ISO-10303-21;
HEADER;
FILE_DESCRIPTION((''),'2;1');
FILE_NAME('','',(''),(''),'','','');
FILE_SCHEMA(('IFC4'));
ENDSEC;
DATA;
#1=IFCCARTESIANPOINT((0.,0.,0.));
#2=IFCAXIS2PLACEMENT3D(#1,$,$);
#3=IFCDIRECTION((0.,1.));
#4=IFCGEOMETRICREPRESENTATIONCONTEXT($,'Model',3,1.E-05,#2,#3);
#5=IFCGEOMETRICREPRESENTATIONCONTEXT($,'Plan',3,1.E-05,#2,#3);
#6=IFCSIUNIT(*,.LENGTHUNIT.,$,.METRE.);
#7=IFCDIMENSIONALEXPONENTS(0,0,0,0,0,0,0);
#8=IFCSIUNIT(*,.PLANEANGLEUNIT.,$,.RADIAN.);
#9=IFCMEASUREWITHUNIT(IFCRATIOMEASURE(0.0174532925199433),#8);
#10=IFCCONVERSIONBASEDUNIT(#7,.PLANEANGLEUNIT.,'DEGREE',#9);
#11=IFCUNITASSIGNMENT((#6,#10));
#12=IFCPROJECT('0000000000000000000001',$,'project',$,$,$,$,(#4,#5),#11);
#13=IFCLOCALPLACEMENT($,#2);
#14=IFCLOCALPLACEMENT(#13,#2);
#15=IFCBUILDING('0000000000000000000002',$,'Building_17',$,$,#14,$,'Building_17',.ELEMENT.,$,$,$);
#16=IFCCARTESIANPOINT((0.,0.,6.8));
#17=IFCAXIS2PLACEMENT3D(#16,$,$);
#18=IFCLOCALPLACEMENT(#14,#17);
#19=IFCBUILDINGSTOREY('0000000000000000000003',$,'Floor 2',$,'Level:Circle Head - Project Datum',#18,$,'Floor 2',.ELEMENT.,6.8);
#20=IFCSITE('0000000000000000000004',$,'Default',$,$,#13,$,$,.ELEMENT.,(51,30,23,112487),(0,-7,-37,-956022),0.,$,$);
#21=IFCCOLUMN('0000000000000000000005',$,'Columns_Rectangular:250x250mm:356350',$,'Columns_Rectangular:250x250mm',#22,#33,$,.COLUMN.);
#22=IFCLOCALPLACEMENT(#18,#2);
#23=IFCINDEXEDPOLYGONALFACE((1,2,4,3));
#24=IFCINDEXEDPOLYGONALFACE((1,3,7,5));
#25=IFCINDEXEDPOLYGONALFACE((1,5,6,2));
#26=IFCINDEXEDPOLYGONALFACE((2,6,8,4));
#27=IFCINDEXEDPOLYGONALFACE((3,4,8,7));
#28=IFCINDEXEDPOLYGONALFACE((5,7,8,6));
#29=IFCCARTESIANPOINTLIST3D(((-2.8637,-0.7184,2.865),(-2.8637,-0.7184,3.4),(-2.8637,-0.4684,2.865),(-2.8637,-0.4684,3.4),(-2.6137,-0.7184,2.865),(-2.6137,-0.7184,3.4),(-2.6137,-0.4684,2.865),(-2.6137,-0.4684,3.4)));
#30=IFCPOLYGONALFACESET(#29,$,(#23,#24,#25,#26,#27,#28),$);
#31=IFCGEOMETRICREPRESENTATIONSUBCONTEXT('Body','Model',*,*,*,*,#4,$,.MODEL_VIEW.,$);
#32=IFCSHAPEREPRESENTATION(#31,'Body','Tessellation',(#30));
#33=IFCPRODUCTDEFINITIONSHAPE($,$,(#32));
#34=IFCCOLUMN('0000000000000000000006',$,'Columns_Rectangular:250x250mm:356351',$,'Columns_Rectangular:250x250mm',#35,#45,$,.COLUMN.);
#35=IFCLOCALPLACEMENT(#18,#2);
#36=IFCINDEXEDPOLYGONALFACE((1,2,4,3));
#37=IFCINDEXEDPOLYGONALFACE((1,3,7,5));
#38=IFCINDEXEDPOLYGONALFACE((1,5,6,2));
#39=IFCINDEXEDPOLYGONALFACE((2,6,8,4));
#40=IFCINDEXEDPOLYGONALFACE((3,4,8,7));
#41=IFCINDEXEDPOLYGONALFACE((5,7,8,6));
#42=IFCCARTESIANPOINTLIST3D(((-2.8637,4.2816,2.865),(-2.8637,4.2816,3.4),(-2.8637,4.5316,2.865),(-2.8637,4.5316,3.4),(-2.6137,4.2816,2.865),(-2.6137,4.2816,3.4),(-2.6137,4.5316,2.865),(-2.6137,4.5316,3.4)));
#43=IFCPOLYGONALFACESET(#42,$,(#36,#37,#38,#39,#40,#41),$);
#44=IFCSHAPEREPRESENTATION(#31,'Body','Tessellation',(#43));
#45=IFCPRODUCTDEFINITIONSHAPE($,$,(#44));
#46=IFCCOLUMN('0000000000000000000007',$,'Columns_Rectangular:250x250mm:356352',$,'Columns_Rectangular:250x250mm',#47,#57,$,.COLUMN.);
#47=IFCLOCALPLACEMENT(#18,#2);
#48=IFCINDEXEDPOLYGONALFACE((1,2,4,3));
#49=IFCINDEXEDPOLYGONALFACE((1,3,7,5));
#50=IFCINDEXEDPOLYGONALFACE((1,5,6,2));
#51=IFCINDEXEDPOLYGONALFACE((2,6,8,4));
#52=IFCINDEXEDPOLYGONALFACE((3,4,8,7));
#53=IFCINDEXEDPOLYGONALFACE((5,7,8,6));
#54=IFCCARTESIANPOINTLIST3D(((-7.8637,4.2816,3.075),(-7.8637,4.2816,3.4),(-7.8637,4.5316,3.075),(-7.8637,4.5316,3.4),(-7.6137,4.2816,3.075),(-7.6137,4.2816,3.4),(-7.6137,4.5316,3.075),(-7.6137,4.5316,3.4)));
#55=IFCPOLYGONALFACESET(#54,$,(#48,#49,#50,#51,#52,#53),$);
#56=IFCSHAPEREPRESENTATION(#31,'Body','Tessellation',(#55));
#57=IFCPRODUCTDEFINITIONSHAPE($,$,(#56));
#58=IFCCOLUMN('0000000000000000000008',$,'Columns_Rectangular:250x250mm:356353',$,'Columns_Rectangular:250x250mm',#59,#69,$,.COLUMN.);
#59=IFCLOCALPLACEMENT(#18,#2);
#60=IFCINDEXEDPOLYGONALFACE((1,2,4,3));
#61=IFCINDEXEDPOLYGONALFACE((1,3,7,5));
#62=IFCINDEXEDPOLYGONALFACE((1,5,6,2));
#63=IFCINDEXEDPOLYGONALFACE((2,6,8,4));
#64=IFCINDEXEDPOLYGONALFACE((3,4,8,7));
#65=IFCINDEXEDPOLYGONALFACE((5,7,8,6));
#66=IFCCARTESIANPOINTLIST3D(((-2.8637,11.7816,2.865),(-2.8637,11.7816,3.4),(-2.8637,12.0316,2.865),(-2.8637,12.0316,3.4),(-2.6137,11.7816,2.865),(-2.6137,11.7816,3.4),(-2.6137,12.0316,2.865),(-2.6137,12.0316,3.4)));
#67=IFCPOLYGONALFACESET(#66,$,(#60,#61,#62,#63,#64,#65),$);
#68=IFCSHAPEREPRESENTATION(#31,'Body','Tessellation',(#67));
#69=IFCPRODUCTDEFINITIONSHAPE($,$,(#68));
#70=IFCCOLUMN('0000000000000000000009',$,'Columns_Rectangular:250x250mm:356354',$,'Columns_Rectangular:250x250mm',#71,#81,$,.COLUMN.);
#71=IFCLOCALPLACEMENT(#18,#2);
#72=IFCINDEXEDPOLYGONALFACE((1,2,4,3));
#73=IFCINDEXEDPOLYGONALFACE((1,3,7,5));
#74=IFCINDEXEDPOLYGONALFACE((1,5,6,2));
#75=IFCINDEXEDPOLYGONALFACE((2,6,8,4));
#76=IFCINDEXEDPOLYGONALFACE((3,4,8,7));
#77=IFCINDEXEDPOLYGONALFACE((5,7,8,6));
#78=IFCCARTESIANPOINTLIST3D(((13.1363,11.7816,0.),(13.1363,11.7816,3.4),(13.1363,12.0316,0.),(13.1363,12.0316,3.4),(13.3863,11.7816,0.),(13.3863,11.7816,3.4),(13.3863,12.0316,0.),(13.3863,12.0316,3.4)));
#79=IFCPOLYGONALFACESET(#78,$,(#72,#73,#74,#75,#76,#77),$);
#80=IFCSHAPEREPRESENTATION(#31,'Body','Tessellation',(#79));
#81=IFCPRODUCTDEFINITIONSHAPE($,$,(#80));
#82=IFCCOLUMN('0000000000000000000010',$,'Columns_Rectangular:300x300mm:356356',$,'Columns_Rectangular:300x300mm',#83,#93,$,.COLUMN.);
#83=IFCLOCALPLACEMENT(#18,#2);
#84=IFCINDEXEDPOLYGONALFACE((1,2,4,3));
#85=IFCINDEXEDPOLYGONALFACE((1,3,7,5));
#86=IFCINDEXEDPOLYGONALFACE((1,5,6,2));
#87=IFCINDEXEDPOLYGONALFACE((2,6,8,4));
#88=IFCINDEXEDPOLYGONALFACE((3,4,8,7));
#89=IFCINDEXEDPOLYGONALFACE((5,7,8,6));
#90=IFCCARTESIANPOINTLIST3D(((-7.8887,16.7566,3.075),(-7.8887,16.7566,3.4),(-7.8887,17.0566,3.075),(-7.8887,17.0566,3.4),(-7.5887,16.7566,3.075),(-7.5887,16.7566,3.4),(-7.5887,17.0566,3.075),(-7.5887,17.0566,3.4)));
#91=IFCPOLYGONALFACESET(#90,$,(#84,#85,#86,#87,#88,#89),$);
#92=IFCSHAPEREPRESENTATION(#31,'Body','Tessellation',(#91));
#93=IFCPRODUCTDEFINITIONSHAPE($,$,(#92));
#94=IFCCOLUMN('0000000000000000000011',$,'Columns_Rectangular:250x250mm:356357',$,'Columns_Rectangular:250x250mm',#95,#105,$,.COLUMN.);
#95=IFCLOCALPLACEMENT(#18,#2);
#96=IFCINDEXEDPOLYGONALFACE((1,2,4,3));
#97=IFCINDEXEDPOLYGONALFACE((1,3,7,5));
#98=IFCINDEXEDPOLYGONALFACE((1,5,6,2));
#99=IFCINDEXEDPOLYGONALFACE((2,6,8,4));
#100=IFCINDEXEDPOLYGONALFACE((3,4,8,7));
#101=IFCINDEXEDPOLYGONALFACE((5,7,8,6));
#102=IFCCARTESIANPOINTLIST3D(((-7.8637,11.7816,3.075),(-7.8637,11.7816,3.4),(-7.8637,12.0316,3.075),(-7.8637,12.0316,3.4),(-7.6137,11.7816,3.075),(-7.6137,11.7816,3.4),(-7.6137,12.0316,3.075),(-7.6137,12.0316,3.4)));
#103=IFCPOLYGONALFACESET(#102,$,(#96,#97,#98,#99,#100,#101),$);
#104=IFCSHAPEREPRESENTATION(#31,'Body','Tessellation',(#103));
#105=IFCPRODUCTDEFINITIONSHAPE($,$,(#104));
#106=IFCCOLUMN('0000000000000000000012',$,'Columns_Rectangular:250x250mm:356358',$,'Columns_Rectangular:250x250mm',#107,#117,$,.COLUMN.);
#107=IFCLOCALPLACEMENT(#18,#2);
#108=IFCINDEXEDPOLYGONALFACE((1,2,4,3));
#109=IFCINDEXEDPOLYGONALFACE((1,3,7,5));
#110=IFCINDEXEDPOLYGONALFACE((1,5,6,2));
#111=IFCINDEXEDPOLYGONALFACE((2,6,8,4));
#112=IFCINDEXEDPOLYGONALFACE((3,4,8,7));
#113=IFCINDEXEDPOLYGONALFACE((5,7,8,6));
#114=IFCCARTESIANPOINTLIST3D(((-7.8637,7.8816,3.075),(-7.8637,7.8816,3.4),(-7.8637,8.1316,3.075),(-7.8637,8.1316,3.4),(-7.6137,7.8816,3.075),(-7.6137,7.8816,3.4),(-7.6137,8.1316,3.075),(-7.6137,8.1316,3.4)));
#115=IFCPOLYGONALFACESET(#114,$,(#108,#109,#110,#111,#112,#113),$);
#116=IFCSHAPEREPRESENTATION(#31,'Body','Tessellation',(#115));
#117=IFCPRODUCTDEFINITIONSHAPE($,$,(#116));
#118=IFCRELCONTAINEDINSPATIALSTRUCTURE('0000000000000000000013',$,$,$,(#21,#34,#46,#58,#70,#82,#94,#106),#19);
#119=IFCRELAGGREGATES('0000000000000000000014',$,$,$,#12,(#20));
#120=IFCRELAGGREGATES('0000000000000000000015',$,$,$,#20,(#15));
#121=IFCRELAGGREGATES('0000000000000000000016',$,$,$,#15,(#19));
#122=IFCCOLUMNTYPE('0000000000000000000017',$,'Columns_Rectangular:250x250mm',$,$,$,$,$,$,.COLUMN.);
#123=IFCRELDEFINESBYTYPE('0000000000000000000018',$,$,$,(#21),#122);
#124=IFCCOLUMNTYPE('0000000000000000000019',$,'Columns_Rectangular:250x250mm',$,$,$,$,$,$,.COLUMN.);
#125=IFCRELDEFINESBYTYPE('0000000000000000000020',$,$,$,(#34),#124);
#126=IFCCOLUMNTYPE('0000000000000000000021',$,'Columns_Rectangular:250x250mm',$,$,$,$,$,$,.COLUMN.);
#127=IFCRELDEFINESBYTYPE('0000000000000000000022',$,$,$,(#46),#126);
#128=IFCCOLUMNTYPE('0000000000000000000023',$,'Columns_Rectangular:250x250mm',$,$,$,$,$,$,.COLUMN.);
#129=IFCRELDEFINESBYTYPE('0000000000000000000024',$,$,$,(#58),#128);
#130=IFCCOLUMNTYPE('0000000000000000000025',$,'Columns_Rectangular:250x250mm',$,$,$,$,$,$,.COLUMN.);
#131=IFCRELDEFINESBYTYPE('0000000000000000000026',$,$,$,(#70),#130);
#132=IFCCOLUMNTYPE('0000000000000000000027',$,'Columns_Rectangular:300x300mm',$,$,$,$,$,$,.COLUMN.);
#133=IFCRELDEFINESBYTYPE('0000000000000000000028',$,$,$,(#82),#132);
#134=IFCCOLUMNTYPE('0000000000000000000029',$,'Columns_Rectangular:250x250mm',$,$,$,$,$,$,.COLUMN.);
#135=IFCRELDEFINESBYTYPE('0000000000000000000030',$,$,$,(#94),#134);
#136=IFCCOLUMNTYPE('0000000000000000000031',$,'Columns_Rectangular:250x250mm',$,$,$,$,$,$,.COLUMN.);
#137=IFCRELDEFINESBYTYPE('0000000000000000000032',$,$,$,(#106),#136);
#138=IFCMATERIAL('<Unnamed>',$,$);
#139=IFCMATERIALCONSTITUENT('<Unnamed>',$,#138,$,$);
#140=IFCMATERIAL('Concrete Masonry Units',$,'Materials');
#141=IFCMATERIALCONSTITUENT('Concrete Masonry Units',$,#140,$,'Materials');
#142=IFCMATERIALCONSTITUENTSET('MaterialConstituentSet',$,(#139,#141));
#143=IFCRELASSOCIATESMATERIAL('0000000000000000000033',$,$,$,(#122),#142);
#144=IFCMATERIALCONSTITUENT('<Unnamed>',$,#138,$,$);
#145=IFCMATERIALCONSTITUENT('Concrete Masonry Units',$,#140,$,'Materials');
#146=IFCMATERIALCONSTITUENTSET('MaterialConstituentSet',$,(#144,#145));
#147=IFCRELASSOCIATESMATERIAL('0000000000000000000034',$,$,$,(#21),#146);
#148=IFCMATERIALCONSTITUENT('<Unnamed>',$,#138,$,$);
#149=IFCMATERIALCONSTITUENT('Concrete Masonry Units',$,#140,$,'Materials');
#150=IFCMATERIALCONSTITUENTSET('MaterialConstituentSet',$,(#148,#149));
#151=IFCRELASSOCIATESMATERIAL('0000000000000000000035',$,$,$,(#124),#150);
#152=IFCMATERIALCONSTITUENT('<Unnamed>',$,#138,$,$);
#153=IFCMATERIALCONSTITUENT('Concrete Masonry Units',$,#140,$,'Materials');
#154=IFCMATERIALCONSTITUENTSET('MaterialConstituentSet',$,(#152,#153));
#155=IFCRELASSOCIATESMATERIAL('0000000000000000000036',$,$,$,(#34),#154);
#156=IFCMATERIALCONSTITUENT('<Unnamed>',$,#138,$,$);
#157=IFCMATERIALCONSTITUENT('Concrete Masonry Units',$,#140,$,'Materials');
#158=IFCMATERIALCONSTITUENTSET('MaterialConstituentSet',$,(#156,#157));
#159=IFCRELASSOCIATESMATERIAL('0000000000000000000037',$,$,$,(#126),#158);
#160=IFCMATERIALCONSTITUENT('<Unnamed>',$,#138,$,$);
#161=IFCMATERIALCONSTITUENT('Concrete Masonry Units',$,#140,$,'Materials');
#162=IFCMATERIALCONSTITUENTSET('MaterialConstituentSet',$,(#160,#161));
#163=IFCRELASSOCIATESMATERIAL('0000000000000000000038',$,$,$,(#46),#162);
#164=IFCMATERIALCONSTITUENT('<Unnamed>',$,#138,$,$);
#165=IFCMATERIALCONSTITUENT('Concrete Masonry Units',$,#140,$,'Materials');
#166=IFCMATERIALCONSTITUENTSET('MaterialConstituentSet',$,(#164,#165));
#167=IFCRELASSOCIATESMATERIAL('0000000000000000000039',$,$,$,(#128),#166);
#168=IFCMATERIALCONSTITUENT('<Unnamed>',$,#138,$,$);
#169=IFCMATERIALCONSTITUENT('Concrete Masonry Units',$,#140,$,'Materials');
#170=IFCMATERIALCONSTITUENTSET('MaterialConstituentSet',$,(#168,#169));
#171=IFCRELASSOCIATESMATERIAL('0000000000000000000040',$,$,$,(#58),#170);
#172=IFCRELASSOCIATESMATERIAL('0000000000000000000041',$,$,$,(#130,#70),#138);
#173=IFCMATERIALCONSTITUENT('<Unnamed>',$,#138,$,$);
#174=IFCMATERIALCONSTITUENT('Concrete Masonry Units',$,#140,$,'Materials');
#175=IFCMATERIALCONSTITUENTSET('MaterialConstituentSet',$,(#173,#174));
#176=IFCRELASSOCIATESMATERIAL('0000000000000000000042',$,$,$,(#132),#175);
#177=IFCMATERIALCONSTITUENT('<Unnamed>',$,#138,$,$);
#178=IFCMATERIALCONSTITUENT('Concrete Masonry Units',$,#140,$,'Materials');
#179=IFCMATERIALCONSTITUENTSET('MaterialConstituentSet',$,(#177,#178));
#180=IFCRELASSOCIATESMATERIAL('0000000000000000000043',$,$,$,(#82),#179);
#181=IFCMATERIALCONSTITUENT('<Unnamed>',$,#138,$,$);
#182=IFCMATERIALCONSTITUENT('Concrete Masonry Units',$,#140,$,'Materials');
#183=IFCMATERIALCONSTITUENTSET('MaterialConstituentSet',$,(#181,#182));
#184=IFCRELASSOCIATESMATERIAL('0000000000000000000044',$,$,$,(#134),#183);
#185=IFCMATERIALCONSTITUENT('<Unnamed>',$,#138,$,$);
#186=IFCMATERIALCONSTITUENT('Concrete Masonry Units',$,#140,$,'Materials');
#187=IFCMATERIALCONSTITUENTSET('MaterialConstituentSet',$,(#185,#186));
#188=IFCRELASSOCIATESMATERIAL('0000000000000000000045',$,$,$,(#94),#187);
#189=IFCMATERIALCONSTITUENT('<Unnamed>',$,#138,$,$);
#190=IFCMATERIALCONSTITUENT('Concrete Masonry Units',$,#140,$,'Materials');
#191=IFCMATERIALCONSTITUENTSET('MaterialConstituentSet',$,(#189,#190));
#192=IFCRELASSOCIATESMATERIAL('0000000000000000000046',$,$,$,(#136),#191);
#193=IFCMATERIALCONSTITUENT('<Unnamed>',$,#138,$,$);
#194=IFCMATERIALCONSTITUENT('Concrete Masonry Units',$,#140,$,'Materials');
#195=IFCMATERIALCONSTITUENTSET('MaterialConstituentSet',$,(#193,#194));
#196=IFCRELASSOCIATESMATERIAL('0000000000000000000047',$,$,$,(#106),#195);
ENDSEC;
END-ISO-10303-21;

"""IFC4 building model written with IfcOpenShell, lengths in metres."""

from ifc_helpers import new_model, entity, si_unit, converted_unit, direction, frame, origin, place, context, subcontext, project, spatial, indexed_curve, outline, extrude, source, transform, mapped, material, constituent, constituent_set, type_object, type_shapes, element, save


model = new_model("IFC4")

# Units and contexts
model_context = context("Model", 3, precision=1e-05, world=origin(), true_north=direction((0.0, 1.0)))
plan_context = context("Plan", 3, precision=1e-05, world=origin(), true_north=direction((0.0, 1.0)))
body_context = subcontext(model_context, "Body", "Model", "MODEL_VIEW")
ifc_project = project(units=[si_unit("LENGTHUNIT", "METRE"), converted_unit("PLANEANGLEUNIT", "DEGREE", entity("IfcRatioMeasure", 0.0174532925199433), si_unit("PLANEANGLEUNIT", "RADIAN"), dimensions=[0, 0, 0, 0, 0, 0, 0])], contexts=[model_context, plan_context])

# Site, building, storey
site_placement = place(None, origin())
site = spatial("IfcSite", under=ifc_project, at=site_placement, Name="Default", CompositionType="ELEMENT", RefLatitude=(51, 30, 23, 112487), RefLongitude=(0, -7, -37, -956022), RefElevation=0.0)
building_placement = place(site_placement, origin())
building = spatial("IfcBuilding", under=site, at=building_placement, Name="Building_17", LongName="Building_17", CompositionType="ELEMENT")
storey_placement = place(building_placement, frame((0.0, 0.0, 6.8)))
storey = spatial("IfcBuildingStorey", under=building, at=storey_placement, Name="Floor 2", ObjectType="Level:Circle Head - Project Datum", LongName="Floor 2", CompositionType="ELEMENT", Elevation=6.8)

# Columns
ifc_material_1 = material(Name="<Unnamed>")
ifc_constituent_1 = constituent(ifc_material_1, Name="<Unnamed>")
ifc_material_2 = material(Name="Concrete Masonry Units", Category="Materials")
ifc_constituent_2 = constituent(ifc_material_2, Name="Concrete Masonry Units", Category="Materials")
ifc_constituent_set_1 = constituent_set(constituents=[ifc_constituent_1, ifc_constituent_2], Name="MaterialConstituentSet")
ifc_constituent_3 = constituent(ifc_material_1, Name="<Unnamed>")
ifc_constituent_4 = constituent(ifc_material_2, Name="Concrete Masonry Units", Category="Materials")
ifc_constituent_set_2 = constituent_set(constituents=[ifc_constituent_3, ifc_constituent_4], Name="MaterialConstituentSet")
column_type_1 = type_object("IfcColumnType", Name="Columns_Rectangular:250x250mm", PredefinedType="COLUMN", material=ifc_constituent_set_2)
shared_shape_1 = source(origin(), body_context, "Body", "SweptSolid", [
    extrude(outline(indexed_curve([(-0.125, -0.125), (0.125, -0.125), (0.125, 0.125), (-0.125, 0.125), (-0.125, -0.125)], self_intersect=False)), frame((-2.7387, -0.5934, 9.665), z_axis=(0.0, 0.0, 1.0), x_axis=(0.0, -1.0, 0.0)), (0.0, 0.0, 1.0), 0.535),
])
type_shapes(column_type_1, [shared_shape_1])
column_1_placement = place(storey_placement, frame((0.0, 0.0, -6.8)))
element("IfcColumn", 1, at=column_1_placement, inside=storey, type_object=column_type_1, material=ifc_constituent_set_1, Name="Columns_Rectangular:250x250mm:356350", ObjectType="Columns_Rectangular:250x250mm", PredefinedType="COLUMN", context=body_context, shape_type="MappedRepresentation", body=[
    mapped(shared_shape_1, transform((0.0, 0.0, 0.0), scale=1.0)),
])
ifc_constituent_5 = constituent(ifc_material_1, Name="<Unnamed>")
ifc_constituent_6 = constituent(ifc_material_2, Name="Concrete Masonry Units", Category="Materials")
ifc_constituent_set_3 = constituent_set(constituents=[ifc_constituent_5, ifc_constituent_6], Name="MaterialConstituentSet")
ifc_constituent_7 = constituent(ifc_material_1, Name="<Unnamed>")
ifc_constituent_8 = constituent(ifc_material_2, Name="Concrete Masonry Units", Category="Materials")
ifc_constituent_set_4 = constituent_set(constituents=[ifc_constituent_7, ifc_constituent_8], Name="MaterialConstituentSet")
column_type_2 = type_object("IfcColumnType", Name="Columns_Rectangular:250x250mm", PredefinedType="COLUMN", material=ifc_constituent_set_4)
shared_shape_2 = source(origin(), body_context, "Body", "SweptSolid", [
    extrude(outline(indexed_curve([(-0.125, -0.125), (0.125, -0.125), (0.125, 0.125), (-0.125, 0.125), (-0.125, -0.125)], self_intersect=False)), frame((-2.7387, 4.4066, 9.665), z_axis=(0.0, 0.0, 1.0), x_axis=(0.0, -1.0, 0.0)), (0.0, 0.0, 1.0), 0.535),
])
type_shapes(column_type_2, [shared_shape_2])
column_2_placement = place(storey_placement, frame((0.0, 0.0, -6.8)))
element("IfcColumn", 2, at=column_2_placement, inside=storey, type_object=column_type_2, material=ifc_constituent_set_3, Name="Columns_Rectangular:250x250mm:356351", ObjectType="Columns_Rectangular:250x250mm", PredefinedType="COLUMN", context=body_context, shape_type="MappedRepresentation", body=[
    mapped(shared_shape_2, transform((0.0, 0.0, 0.0), scale=1.0)),
])
ifc_constituent_9 = constituent(ifc_material_1, Name="<Unnamed>")
ifc_constituent_10 = constituent(ifc_material_2, Name="Concrete Masonry Units", Category="Materials")
ifc_constituent_set_5 = constituent_set(constituents=[ifc_constituent_9, ifc_constituent_10], Name="MaterialConstituentSet")
ifc_constituent_11 = constituent(ifc_material_1, Name="<Unnamed>")
ifc_constituent_12 = constituent(ifc_material_2, Name="Concrete Masonry Units", Category="Materials")
ifc_constituent_set_6 = constituent_set(constituents=[ifc_constituent_11, ifc_constituent_12], Name="MaterialConstituentSet")
column_type_3 = type_object("IfcColumnType", Name="Columns_Rectangular:250x250mm", PredefinedType="COLUMN", material=ifc_constituent_set_6)
shared_shape_3 = source(origin(), body_context, "Body", "SweptSolid", [
    extrude(outline(indexed_curve([(-0.125, -0.125), (0.125, -0.125), (0.125, 0.125), (-0.125, 0.125), (-0.125, -0.125)], self_intersect=False)), frame((-7.7387, 4.4066, 9.875), z_axis=(0.0, 0.0, 1.0), x_axis=(0.0, -1.0, 0.0)), (0.0, 0.0, 1.0), 0.325),
])
type_shapes(column_type_3, [shared_shape_3])
column_3_placement = place(storey_placement, frame((0.0, 0.0, -6.8)))
element("IfcColumn", 3, at=column_3_placement, inside=storey, type_object=column_type_3, material=ifc_constituent_set_5, Name="Columns_Rectangular:250x250mm:356352", ObjectType="Columns_Rectangular:250x250mm", PredefinedType="COLUMN", context=body_context, shape_type="MappedRepresentation", body=[
    mapped(shared_shape_3, transform((0.0, 0.0, 0.0), scale=1.0)),
])
ifc_constituent_13 = constituent(ifc_material_1, Name="<Unnamed>")
ifc_constituent_14 = constituent(ifc_material_2, Name="Concrete Masonry Units", Category="Materials")
ifc_constituent_set_7 = constituent_set(constituents=[ifc_constituent_13, ifc_constituent_14], Name="MaterialConstituentSet")
ifc_constituent_15 = constituent(ifc_material_1, Name="<Unnamed>")
ifc_constituent_16 = constituent(ifc_material_2, Name="Concrete Masonry Units", Category="Materials")
ifc_constituent_set_8 = constituent_set(constituents=[ifc_constituent_15, ifc_constituent_16], Name="MaterialConstituentSet")
column_type_4 = type_object("IfcColumnType", Name="Columns_Rectangular:250x250mm", PredefinedType="COLUMN", material=ifc_constituent_set_8)
shared_shape_4 = source(origin(), body_context, "Body", "SweptSolid", [
    extrude(outline(indexed_curve([(-0.125, -0.125), (0.125, -0.125), (0.125, 0.125), (-0.125, 0.125), (-0.125, -0.125)], self_intersect=False)), frame((-2.7387, 11.9066, 9.665), z_axis=(0.0, 0.0, 1.0), x_axis=(0.0, -1.0, 0.0)), (0.0, 0.0, 1.0), 0.535),
])
type_shapes(column_type_4, [shared_shape_4])
column_4_placement = place(storey_placement, frame((0.0, 0.0, -6.8)))
element("IfcColumn", 4, at=column_4_placement, inside=storey, type_object=column_type_4, material=ifc_constituent_set_7, Name="Columns_Rectangular:250x250mm:356353", ObjectType="Columns_Rectangular:250x250mm", PredefinedType="COLUMN", context=body_context, shape_type="MappedRepresentation", body=[
    mapped(shared_shape_4, transform((0.0, 0.0, 0.0), scale=1.0)),
])
column_type_5 = type_object("IfcColumnType", Name="Columns_Rectangular:250x250mm", PredefinedType="COLUMN", material=ifc_material_1)
shared_shape_5 = source(origin(), body_context, "Body", "SweptSolid", [
    extrude(outline(indexed_curve([(-0.125, -0.125), (0.125, -0.125), (0.125, 0.125), (-0.125, 0.125), (-0.125, -0.125)], self_intersect=False)), frame((13.2613, 11.9066, 6.8), z_axis=(0.0, 0.0, 1.0), x_axis=(0.0, -1.0, 0.0)), (0.0, 0.0, 1.0), 3.4),
])
type_shapes(column_type_5, [shared_shape_5])
column_5_placement = place(storey_placement, frame((0.0, 0.0, -6.8)))
element("IfcColumn", 5, at=column_5_placement, inside=storey, type_object=column_type_5, material=ifc_material_1, Name="Columns_Rectangular:250x250mm:356354", ObjectType="Columns_Rectangular:250x250mm", PredefinedType="COLUMN", context=body_context, shape_type="MappedRepresentation", body=[
    mapped(shared_shape_5, transform((0.0, 0.0, 0.0), scale=1.0)),
])
ifc_constituent_17 = constituent(ifc_material_1, Name="<Unnamed>")
ifc_constituent_18 = constituent(ifc_material_2, Name="Concrete Masonry Units", Category="Materials")
ifc_constituent_set_9 = constituent_set(constituents=[ifc_constituent_17, ifc_constituent_18], Name="MaterialConstituentSet")
ifc_constituent_19 = constituent(ifc_material_1, Name="<Unnamed>")
ifc_constituent_20 = constituent(ifc_material_2, Name="Concrete Masonry Units", Category="Materials")
ifc_constituent_set_10 = constituent_set(constituents=[ifc_constituent_19, ifc_constituent_20], Name="MaterialConstituentSet")
column_type_6 = type_object("IfcColumnType", Name="Columns_Rectangular:300x300mm", PredefinedType="COLUMN", material=ifc_constituent_set_10)
shared_shape_6 = source(origin(), body_context, "Body", "SweptSolid", [
    extrude(outline(indexed_curve([(-0.15, -0.15), (0.15, -0.15), (0.15, 0.15), (-0.15, 0.15), (-0.15, -0.15)], self_intersect=False)), frame((-7.7387, 16.9066, 9.875), z_axis=(0.0, 0.0, 1.0), x_axis=(0.0, -1.0, 0.0)), (0.0, 0.0, 1.0), 0.325),
])
type_shapes(column_type_6, [shared_shape_6])
column_6_placement = place(storey_placement, frame((0.0, 0.0, -6.8)))
element("IfcColumn", 6, at=column_6_placement, inside=storey, type_object=column_type_6, material=ifc_constituent_set_9, Name="Columns_Rectangular:300x300mm:356356", ObjectType="Columns_Rectangular:300x300mm", PredefinedType="COLUMN", context=body_context, shape_type="MappedRepresentation", body=[
    mapped(shared_shape_6, transform((0.0, 0.0, 0.0), scale=1.0)),
])
ifc_constituent_21 = constituent(ifc_material_1, Name="<Unnamed>")
ifc_constituent_22 = constituent(ifc_material_2, Name="Concrete Masonry Units", Category="Materials")
ifc_constituent_set_11 = constituent_set(constituents=[ifc_constituent_21, ifc_constituent_22], Name="MaterialConstituentSet")
ifc_constituent_23 = constituent(ifc_material_1, Name="<Unnamed>")
ifc_constituent_24 = constituent(ifc_material_2, Name="Concrete Masonry Units", Category="Materials")
ifc_constituent_set_12 = constituent_set(constituents=[ifc_constituent_23, ifc_constituent_24], Name="MaterialConstituentSet")
column_type_7 = type_object("IfcColumnType", Name="Columns_Rectangular:250x250mm", PredefinedType="COLUMN", material=ifc_constituent_set_12)
shared_shape_7 = source(origin(), body_context, "Body", "SweptSolid", [
    extrude(outline(indexed_curve([(-0.125, -0.125), (0.125, -0.125), (0.125, 0.125), (-0.125, 0.125), (-0.125, -0.125)], self_intersect=False)), frame((-7.7387, 11.9066, 9.875), z_axis=(0.0, 0.0, 1.0), x_axis=(0.0, -1.0, 0.0)), (0.0, 0.0, 1.0), 0.325),
])
type_shapes(column_type_7, [shared_shape_7])
column_7_placement = place(storey_placement, frame((0.0, 0.0, -6.8)))
element("IfcColumn", 7, at=column_7_placement, inside=storey, type_object=column_type_7, material=ifc_constituent_set_11, Name="Columns_Rectangular:250x250mm:356357", ObjectType="Columns_Rectangular:250x250mm", PredefinedType="COLUMN", context=body_context, shape_type="MappedRepresentation", body=[
    mapped(shared_shape_7, transform((0.0, 0.0, 0.0), scale=1.0)),
])
ifc_constituent_25 = constituent(ifc_material_1, Name="<Unnamed>")
ifc_constituent_26 = constituent(ifc_material_2, Name="Concrete Masonry Units", Category="Materials")
ifc_constituent_set_13 = constituent_set(constituents=[ifc_constituent_25, ifc_constituent_26], Name="MaterialConstituentSet")
ifc_constituent_27 = constituent(ifc_material_1, Name="<Unnamed>")
ifc_constituent_28 = constituent(ifc_material_2, Name="Concrete Masonry Units", Category="Materials")
ifc_constituent_set_14 = constituent_set(constituents=[ifc_constituent_27, ifc_constituent_28], Name="MaterialConstituentSet")
column_type_8 = type_object("IfcColumnType", Name="Columns_Rectangular:250x250mm", PredefinedType="COLUMN", material=ifc_constituent_set_14)
shared_shape_8 = source(origin(), body_context, "Body", "SweptSolid", [
    extrude(outline(indexed_curve([(-0.125, -0.125), (0.125, -0.125), (0.125, 0.125), (-0.125, 0.125), (-0.125, -0.125)], self_intersect=False)), frame((-7.7387, 8.0066, 9.875), z_axis=(0.0, 0.0, 1.0), x_axis=(0.0, -1.0, 0.0)), (0.0, 0.0, 1.0), 0.325),
])
type_shapes(column_type_8, [shared_shape_8])
column_8_placement = place(storey_placement, frame((0.0, 0.0, -6.8)))
element("IfcColumn", 8, at=column_8_placement, inside=storey, type_object=column_type_8, material=ifc_constituent_set_13, Name="Columns_Rectangular:250x250mm:356358", ObjectType="Columns_Rectangular:250x250mm", PredefinedType="COLUMN", context=body_context, shape_type="MappedRepresentation", body=[
    mapped(shared_shape_8, transform((0.0, 0.0, 0.0), scale=1.0)),
])

save(model, "model.ifc")
